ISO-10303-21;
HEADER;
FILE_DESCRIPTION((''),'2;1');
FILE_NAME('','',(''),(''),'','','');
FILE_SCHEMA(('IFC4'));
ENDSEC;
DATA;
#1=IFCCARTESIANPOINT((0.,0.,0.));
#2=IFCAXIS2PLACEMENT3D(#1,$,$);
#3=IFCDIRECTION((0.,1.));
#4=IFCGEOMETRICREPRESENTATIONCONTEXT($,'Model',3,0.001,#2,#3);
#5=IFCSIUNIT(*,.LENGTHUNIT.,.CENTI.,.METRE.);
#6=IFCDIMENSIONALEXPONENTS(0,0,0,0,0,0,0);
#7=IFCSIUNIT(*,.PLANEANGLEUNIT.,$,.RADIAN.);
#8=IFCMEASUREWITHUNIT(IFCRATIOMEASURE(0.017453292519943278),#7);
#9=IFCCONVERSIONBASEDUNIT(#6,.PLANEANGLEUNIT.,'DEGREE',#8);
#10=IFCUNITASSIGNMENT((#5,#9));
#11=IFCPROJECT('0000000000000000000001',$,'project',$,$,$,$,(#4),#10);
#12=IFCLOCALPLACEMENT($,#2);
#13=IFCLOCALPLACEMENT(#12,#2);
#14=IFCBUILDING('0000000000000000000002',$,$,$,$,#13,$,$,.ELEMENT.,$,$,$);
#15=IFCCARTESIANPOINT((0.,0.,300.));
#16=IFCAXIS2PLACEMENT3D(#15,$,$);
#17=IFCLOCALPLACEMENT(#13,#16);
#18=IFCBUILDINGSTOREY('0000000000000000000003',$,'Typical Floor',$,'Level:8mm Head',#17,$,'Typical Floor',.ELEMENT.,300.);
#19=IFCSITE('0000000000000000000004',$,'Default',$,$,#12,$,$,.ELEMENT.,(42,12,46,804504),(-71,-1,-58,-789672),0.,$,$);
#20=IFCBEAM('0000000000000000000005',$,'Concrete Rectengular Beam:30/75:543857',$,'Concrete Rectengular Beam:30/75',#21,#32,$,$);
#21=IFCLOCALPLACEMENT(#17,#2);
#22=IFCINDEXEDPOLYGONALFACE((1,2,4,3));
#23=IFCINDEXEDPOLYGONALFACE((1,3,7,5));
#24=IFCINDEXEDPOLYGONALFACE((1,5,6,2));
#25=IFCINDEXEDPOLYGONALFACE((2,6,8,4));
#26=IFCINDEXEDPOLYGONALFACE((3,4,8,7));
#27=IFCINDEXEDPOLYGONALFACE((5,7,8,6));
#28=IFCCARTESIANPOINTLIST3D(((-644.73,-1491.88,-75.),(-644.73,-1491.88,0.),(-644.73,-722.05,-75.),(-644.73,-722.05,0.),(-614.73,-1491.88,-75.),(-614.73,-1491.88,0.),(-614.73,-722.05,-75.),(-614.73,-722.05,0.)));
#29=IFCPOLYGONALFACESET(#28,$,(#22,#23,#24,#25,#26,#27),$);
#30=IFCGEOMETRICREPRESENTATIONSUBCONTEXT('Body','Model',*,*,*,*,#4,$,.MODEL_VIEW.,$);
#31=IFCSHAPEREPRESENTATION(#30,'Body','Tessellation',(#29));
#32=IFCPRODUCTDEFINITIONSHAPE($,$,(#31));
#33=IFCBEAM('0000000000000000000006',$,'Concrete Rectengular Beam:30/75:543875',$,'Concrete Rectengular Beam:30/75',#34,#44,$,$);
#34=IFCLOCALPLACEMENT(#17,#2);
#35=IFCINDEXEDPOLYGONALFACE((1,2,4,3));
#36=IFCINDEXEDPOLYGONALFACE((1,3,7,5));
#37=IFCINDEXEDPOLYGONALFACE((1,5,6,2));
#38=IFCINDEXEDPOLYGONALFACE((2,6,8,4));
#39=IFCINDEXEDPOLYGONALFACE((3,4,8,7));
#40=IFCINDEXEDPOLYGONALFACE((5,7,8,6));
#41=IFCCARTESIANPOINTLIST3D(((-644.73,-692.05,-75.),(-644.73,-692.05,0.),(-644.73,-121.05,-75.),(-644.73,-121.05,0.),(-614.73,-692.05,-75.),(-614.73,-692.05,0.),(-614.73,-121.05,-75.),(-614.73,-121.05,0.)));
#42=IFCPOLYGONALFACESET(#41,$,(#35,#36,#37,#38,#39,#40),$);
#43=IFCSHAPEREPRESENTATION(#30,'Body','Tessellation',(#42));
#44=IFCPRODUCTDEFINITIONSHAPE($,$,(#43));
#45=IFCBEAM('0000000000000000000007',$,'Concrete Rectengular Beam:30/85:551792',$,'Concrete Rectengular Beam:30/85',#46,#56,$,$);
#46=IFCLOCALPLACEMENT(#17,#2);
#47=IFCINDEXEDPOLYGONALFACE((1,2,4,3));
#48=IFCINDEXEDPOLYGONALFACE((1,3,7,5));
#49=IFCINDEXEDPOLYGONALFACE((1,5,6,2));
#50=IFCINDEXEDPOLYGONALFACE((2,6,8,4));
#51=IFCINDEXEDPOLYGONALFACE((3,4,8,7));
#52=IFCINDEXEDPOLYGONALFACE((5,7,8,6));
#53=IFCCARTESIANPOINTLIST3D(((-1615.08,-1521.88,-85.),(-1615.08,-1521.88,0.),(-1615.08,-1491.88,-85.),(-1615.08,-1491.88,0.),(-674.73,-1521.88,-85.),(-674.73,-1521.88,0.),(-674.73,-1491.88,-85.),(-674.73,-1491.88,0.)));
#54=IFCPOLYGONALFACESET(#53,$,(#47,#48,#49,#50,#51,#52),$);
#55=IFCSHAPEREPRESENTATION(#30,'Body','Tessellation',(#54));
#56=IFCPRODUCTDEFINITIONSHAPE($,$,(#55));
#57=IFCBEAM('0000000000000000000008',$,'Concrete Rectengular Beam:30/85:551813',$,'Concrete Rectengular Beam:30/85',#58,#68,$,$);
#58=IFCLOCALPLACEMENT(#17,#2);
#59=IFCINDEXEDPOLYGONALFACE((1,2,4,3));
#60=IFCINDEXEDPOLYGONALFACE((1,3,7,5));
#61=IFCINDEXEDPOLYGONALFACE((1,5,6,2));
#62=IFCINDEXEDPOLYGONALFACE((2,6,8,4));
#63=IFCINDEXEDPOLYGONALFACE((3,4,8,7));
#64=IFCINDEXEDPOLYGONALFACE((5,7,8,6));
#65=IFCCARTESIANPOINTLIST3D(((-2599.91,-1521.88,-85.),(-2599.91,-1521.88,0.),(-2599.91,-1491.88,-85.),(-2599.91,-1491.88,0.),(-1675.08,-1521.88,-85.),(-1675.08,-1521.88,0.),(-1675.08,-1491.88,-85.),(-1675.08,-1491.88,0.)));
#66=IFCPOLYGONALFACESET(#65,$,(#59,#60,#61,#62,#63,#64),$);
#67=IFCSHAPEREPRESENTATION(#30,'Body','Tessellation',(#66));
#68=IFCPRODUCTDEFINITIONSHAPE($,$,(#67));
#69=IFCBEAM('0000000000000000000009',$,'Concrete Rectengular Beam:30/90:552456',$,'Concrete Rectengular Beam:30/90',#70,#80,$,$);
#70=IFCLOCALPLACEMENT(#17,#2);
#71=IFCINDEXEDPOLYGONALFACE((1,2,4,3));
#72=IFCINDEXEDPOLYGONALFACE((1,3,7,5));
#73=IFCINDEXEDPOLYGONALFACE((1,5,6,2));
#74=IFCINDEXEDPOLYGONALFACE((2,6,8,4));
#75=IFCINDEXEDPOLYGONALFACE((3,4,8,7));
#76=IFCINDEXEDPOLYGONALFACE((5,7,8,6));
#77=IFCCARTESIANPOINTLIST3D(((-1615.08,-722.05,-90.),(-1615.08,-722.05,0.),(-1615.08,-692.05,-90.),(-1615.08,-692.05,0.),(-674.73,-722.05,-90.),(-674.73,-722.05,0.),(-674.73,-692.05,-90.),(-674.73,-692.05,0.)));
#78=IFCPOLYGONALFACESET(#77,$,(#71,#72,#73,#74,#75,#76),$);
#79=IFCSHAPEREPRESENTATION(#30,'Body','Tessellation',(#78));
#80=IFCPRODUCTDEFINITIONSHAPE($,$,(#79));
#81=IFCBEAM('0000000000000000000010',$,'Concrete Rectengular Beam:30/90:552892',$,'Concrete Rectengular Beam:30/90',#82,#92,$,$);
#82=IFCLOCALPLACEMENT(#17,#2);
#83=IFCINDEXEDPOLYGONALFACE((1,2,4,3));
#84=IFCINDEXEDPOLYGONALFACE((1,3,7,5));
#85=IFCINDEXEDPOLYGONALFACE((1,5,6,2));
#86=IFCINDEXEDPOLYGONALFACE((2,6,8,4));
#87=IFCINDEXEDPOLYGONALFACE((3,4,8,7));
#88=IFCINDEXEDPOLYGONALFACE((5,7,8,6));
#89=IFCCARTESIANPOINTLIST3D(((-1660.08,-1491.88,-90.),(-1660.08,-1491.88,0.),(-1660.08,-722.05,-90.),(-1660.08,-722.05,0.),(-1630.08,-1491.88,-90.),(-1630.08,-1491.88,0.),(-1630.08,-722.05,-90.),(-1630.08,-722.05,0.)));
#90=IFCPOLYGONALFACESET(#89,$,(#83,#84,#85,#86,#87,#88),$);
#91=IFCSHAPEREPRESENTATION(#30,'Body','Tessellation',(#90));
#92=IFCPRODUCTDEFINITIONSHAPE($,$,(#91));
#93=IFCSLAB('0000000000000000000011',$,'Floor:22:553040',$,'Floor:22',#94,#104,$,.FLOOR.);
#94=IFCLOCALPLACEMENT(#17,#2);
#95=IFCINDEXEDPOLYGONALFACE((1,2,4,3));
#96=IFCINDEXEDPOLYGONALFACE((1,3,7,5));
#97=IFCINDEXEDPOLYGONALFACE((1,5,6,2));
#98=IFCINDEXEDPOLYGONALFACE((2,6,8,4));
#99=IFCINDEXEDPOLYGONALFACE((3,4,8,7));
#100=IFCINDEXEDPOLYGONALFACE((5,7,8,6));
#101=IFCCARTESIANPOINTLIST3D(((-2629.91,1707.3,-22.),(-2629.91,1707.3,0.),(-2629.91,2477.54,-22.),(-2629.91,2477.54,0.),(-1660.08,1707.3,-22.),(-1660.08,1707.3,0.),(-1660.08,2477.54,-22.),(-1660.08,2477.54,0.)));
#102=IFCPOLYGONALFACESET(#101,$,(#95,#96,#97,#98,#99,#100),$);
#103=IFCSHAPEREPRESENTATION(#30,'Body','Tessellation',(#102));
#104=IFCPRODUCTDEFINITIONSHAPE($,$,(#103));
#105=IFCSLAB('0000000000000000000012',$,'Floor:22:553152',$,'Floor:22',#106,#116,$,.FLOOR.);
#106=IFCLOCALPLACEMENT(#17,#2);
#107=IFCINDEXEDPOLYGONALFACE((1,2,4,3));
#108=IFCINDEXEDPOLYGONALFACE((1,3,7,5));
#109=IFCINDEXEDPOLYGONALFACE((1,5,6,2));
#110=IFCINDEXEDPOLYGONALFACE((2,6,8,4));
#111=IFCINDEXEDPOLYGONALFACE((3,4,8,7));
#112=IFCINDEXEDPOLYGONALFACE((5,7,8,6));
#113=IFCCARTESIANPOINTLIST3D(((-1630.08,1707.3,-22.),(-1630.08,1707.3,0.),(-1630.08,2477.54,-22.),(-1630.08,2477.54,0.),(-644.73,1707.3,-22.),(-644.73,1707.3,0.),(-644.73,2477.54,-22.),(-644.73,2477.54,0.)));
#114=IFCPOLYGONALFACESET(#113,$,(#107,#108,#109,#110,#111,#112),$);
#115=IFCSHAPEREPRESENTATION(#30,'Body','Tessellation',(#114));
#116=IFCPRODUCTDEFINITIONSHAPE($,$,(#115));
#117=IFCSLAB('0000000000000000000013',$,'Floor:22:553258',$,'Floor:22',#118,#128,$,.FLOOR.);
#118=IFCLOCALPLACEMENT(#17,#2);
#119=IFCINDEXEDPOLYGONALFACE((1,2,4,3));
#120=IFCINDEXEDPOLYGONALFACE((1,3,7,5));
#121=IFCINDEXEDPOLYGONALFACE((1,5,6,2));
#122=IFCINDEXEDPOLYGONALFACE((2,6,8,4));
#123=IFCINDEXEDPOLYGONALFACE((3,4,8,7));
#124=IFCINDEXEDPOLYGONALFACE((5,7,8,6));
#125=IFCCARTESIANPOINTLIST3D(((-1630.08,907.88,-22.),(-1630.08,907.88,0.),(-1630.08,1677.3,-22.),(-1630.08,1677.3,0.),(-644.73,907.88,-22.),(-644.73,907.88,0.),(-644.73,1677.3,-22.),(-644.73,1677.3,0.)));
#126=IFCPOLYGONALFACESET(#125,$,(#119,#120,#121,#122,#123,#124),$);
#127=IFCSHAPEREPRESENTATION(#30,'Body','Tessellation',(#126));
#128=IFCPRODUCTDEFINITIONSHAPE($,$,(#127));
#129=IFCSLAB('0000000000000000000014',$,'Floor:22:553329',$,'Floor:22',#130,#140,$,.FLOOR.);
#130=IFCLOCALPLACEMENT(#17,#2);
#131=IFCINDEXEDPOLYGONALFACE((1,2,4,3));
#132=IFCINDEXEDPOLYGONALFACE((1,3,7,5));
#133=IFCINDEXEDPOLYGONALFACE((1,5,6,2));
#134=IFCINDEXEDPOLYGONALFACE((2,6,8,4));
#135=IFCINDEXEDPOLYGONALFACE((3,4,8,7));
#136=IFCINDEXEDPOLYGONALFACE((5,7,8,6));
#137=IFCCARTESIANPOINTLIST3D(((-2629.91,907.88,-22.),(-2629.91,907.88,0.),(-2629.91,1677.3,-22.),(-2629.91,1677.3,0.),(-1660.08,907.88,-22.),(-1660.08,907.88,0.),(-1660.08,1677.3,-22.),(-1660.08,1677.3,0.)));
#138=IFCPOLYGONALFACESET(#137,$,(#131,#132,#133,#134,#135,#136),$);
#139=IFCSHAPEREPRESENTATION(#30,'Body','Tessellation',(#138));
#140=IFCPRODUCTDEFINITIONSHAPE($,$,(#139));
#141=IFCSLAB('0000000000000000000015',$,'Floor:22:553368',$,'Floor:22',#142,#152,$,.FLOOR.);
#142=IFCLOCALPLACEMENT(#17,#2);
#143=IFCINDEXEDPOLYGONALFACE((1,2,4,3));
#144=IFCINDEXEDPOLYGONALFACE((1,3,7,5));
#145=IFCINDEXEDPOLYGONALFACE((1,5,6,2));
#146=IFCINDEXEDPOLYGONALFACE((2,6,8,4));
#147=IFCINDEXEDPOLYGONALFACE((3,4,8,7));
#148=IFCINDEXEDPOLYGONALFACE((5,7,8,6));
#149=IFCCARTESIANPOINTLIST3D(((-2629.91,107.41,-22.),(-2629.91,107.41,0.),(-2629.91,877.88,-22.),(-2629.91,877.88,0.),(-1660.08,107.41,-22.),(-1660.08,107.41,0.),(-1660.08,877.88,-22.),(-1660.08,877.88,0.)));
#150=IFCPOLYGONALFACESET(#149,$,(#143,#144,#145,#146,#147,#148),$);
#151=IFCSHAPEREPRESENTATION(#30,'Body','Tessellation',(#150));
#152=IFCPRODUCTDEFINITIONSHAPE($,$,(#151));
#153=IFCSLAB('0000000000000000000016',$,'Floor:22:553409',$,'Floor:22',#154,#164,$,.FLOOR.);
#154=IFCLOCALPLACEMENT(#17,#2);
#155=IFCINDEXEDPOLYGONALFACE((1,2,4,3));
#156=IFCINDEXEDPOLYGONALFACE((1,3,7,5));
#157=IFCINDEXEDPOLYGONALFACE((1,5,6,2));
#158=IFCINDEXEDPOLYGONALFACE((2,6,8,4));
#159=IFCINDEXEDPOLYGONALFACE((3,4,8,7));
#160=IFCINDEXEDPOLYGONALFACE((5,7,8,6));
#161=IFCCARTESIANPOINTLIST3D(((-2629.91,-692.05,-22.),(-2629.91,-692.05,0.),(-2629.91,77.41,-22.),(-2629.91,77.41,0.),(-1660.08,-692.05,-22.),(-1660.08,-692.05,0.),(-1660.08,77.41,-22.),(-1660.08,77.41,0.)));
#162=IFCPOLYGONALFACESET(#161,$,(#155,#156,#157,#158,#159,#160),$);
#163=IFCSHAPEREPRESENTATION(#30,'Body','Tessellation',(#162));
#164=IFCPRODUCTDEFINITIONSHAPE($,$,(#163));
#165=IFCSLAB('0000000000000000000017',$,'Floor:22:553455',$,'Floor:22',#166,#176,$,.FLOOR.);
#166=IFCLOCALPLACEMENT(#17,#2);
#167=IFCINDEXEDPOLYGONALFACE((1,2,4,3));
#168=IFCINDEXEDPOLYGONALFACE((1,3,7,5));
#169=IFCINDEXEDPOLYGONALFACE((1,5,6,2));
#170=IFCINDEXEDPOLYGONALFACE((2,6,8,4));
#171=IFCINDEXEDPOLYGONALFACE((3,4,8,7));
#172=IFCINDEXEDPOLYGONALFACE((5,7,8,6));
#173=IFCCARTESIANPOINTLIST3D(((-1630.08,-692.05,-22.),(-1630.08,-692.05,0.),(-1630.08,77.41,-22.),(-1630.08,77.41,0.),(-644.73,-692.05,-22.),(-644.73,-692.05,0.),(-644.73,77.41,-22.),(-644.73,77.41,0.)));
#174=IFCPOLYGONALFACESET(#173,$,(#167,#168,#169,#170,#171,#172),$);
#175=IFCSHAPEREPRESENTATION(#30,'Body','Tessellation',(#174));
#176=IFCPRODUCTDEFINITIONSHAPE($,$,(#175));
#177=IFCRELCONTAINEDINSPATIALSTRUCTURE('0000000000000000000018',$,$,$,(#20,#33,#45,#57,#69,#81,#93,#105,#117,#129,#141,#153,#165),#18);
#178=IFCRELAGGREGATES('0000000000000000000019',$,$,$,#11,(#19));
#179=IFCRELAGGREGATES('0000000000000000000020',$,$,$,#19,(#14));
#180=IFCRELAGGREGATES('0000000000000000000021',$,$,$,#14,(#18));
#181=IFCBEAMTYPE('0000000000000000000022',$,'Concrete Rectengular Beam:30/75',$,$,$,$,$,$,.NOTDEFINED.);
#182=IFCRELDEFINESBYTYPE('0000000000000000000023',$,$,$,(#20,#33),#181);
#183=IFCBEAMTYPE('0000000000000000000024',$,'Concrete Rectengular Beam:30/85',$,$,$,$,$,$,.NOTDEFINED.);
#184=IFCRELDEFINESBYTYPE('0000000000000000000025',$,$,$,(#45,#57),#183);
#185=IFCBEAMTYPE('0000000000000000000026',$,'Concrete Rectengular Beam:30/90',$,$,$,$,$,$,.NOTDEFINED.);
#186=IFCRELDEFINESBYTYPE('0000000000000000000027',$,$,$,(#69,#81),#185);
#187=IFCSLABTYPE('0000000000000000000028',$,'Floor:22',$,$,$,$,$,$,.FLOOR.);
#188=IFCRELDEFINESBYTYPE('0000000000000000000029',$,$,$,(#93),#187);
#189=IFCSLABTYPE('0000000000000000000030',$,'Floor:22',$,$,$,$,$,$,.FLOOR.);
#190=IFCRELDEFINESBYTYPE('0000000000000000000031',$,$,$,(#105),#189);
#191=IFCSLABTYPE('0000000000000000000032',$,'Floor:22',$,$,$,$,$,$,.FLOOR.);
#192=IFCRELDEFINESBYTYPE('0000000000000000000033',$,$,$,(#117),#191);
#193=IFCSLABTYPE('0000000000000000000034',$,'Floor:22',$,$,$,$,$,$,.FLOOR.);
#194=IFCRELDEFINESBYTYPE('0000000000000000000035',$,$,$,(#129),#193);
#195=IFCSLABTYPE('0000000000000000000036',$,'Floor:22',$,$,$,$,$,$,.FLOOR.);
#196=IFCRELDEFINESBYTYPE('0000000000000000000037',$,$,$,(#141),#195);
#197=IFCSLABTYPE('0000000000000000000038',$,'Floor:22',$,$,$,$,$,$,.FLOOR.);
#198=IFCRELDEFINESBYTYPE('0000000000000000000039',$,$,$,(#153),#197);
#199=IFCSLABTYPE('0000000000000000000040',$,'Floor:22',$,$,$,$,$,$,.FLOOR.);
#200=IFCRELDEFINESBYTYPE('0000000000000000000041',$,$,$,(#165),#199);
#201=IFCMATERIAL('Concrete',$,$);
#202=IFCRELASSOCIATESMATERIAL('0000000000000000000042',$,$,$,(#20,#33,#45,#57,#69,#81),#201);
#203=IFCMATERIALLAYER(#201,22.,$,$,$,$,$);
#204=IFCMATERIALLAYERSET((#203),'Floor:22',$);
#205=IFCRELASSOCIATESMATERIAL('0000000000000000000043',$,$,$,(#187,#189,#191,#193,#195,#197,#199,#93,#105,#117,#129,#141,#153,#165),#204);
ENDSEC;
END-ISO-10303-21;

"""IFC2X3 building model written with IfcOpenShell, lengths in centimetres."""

from ifc_helpers import new_model, entity, si_unit, converted_unit, direction, frame, frame_2d, origin, origin_2d_with_axis, place, context, subcontext, project, spatial, rectangle, extrude, material, layer, layer_set, layer_usage, type_object, element, save


model = new_model("IFC2X3")

# Units and contexts
model_context = context("Model", 3, precision=0.001, world=origin(), true_north=direction((0.0, 1.0)))
body_context = subcontext(model_context, "Body", "Model", "MODEL_VIEW")
ifc_project = project(units=[si_unit("LENGTHUNIT", "METRE", prefix="CENTI"), converted_unit("PLANEANGLEUNIT", "DEGREE", entity("IfcRatioMeasure", 0.017453292519943278), si_unit("PLANEANGLEUNIT", "RADIAN"), dimensions=[0, 0, 0, 0, 0, 0, 0])], contexts=[model_context])

# Site, building, storey
site_placement = place(None, origin())
site = spatial("IfcSite", under=ifc_project, at=site_placement, Name="Default", CompositionType="ELEMENT", RefLatitude=(42, 12, 46, 804504), RefLongitude=(-71, -1, -58, -789672), RefElevation=0.0)
building_placement = place(site_placement, origin())
building = spatial("IfcBuilding", under=site, at=building_placement, CompositionType="ELEMENT")
storey_placement = place(building_placement, frame((0.0, 0.0, 300.0)))
storey = spatial("IfcBuildingStorey", under=building, at=storey_placement, Name="Typical Floor", ObjectType="Level:8mm Head", LongName="Typical Floor", CompositionType="ELEMENT", Elevation=300.0)

# Beams
ifc_material = material(Name="Concrete")
beam_type_1 = type_object("IfcBeamType", Name="Concrete Rectengular Beam:30/75", PredefinedType="NOTDEFINED")
beam_1_placement = place(storey_placement, frame((-629.73, -1506.88, 0.0), z_axis=(0.0, 0.0, 1.0), x_axis=(0.0, 1.0, 0.0)))
element("IfcBeam", 1, at=beam_1_placement, inside=storey, type_object=beam_type_1, material=ifc_material, Name="Concrete Rectengular Beam:30/75:543857", ObjectType="Concrete Rectengular Beam:30/75", context=body_context, shape_type="SweptSolid", body=[
    extrude(rectangle(XDim=75.0, YDim=30.0, at=frame_2d((0.0, 0.0), x_axis=(1.0, 0.0))), frame((15.0, 0.0, -37.5), z_axis=(1.0, 0.0, 0.0), x_axis=(0.0, 0.0, -1.0)), (0.0, 0.0, 1.0), 769.83),
])
beam_2_placement = place(storey_placement, frame((-629.73, -707.05, 0.0), z_axis=(0.0, 0.0, 1.0), x_axis=(0.0, 1.0, 0.0)))
element("IfcBeam", 2, at=beam_2_placement, inside=storey, type_object=beam_type_1, material=ifc_material, Name="Concrete Rectengular Beam:30/75:543875", ObjectType="Concrete Rectengular Beam:30/75", context=body_context, shape_type="SweptSolid", body=[
    extrude(rectangle(XDim=75.0, YDim=30.0, at=frame_2d((0.0, 0.0), x_axis=(1.0, 0.0))), frame((15.0, 0.0, -37.5), z_axis=(1.0, 0.0, 0.0), x_axis=(0.0, 0.0, -1.0)), (0.0, 0.0, 1.0), 571.0),
])
beam_type_2 = type_object("IfcBeamType", Name="Concrete Rectengular Beam:30/85", PredefinedType="NOTDEFINED")
beam_3_placement = place(storey_placement, frame((-644.73, -1506.88, 0.0), z_axis=(0.0, 0.0, 1.0), x_axis=(-1.0, 0.0, 0.0)))
element("IfcBeam", 3, at=beam_3_placement, inside=storey, type_object=beam_type_2, material=ifc_material, Name="Concrete Rectengular Beam:30/85:551792", ObjectType="Concrete Rectengular Beam:30/85", context=body_context, shape_type="SweptSolid", body=[
    extrude(rectangle(XDim=85.0, YDim=30.0, at=frame_2d((0.0, 0.0), x_axis=(1.0, 0.0))), frame((30.0, 0.0, -42.5), z_axis=(1.0, 0.0, 0.0), x_axis=(0.0, 0.0, -1.0)), (0.0, 0.0, 1.0), 940.35),
])
beam_4_placement = place(storey_placement, frame((-1645.08, -1506.88, 0.0), z_axis=(0.0, 0.0, 1.0), x_axis=(-1.0, 0.0, 0.0)))
element("IfcBeam", 4, at=beam_4_placement, inside=storey, type_object=beam_type_2, material=ifc_material, Name="Concrete Rectengular Beam:30/85:551813", ObjectType="Concrete Rectengular Beam:30/85", context=body_context, shape_type="SweptSolid", body=[
    extrude(rectangle(XDim=85.0, YDim=30.0, at=frame_2d((0.0, 0.0), x_axis=(1.0, 0.0))), frame((30.0, 0.0, -42.5), z_axis=(1.0, 0.0, 0.0), x_axis=(0.0, 0.0, -1.0)), (0.0, 0.0, 1.0), 924.83),
])
beam_type_3 = type_object("IfcBeamType", Name="Concrete Rectengular Beam:30/90", PredefinedType="NOTDEFINED")
beam_5_placement = place(storey_placement, frame((-1645.08, -707.05, 0.0)))
element("IfcBeam", 5, at=beam_5_placement, inside=storey, type_object=beam_type_3, material=ifc_material, Name="Concrete Rectengular Beam:30/90:552456", ObjectType="Concrete Rectengular Beam:30/90", context=body_context, shape_type="SweptSolid", body=[
    extrude(rectangle(XDim=90.0, YDim=30.0, at=frame_2d((0.0, 0.0), x_axis=(1.0, 0.0))), frame((30.0, 0.0, -45.0), z_axis=(1.0, 0.0, 0.0), x_axis=(0.0, 0.0, -1.0)), (0.0, 0.0, 1.0), 940.35),
])
beam_6_placement = place(storey_placement, frame((-1645.08, -707.05, 0.0), z_axis=(0.0, 0.0, 1.0), x_axis=(0.0, -1.0, 0.0)))
element("IfcBeam", 6, at=beam_6_placement, inside=storey, type_object=beam_type_3, material=ifc_material, Name="Concrete Rectengular Beam:30/90:552892", ObjectType="Concrete Rectengular Beam:30/90", context=body_context, shape_type="SweptSolid", body=[
    extrude(rectangle(XDim=90.0, YDim=30.0, at=frame_2d((0.0, 0.0), x_axis=(1.0, 0.0))), frame((15.0, 0.0, -45.0), z_axis=(1.0, 0.0, 0.0), x_axis=(0.0, 0.0, -1.0)), (0.0, 0.0, 1.0), 769.83),
])

# Slabs
ifc_layer = layer(ifc_material, 22.0)
ifc_layer_set = layer_set([ifc_layer], Name="Floor:22")
ifc_layer_usage_1 = layer_usage(ifc_layer_set, "AXIS3", "POSITIVE", 0.0)
slab_type_1 = type_object("IfcSlabType", Name="Floor:22", PredefinedType="FLOOR", material=ifc_layer_set)
slab_1_placement = place(storey_placement, origin())
element("IfcSlab", 7, at=slab_1_placement, inside=storey, type_object=slab_type_1, material=ifc_layer_usage_1, Name="Floor:22:553040", ObjectType="Floor:22", PredefinedType="FLOOR", context=body_context, shape_type="SweptSolid", body=[
    extrude(rectangle(XDim=770.24, YDim=969.83, at=frame_2d((0.0, 0.0), x_axis=(1.0, 0.0))), frame((-2144.99, 2092.42, 0.0), z_axis=(0.0, 0.0, -1.0), x_axis=(0.0, 1.0, 0.0)), (0.0, 0.0, 1.0), 22.0),
])
ifc_layer_usage_2 = layer_usage(ifc_layer_set, "AXIS3", "POSITIVE", 0.0)
slab_type_2 = type_object("IfcSlabType", Name="Floor:22", PredefinedType="FLOOR", material=ifc_layer_set)
slab_2_placement = place(storey_placement, origin())
element("IfcSlab", 8, at=slab_2_placement, inside=storey, type_object=slab_type_2, material=ifc_layer_usage_2, Name="Floor:22:553152", ObjectType="Floor:22", PredefinedType="FLOOR", context=body_context, shape_type="SweptSolid", body=[
    extrude(rectangle(XDim=770.24, YDim=985.35, at=frame_2d((0.0, 0.0), x_axis=(1.0, 0.0))), frame((-1137.41, 2092.42, 0.0), z_axis=(0.0, 0.0, -1.0), x_axis=(0.0, 1.0, 0.0)), (0.0, 0.0, 1.0), 22.0),
])
ifc_layer_usage_3 = layer_usage(ifc_layer_set, "AXIS3", "POSITIVE", 0.0)
slab_type_3 = type_object("IfcSlabType", Name="Floor:22", PredefinedType="FLOOR", material=ifc_layer_set)
slab_3_placement = place(storey_placement, origin())
element("IfcSlab", 9, at=slab_3_placement, inside=storey, type_object=slab_type_3, material=ifc_layer_usage_3, Name="Floor:22:553258", ObjectType="Floor:22", PredefinedType="FLOOR", context=body_context, shape_type="SweptSolid", body=[
    extrude(rectangle(XDim=769.42, YDim=985.35, at=frame_2d((0.0, 0.0), x_axis=(1.0, 0.0))), frame((-1137.41, 1292.59, 0.0), z_axis=(0.0, 0.0, -1.0), x_axis=(0.0, 1.0, 0.0)), (0.0, 0.0, 1.0), 22.0),
])
ifc_layer_usage_4 = layer_usage(ifc_layer_set, "AXIS3", "POSITIVE", 0.0)
slab_type_4 = type_object("IfcSlabType", Name="Floor:22", PredefinedType="FLOOR", material=ifc_layer_set)
slab_4_placement = place(storey_placement, origin())
element("IfcSlab", 10, at=slab_4_placement, inside=storey, type_object=slab_type_4, material=ifc_layer_usage_4, Name="Floor:22:553329", ObjectType="Floor:22", PredefinedType="FLOOR", context=body_context, shape_type="SweptSolid", body=[
    extrude(rectangle(XDim=769.42, YDim=969.83, at=frame_2d((0.0, 0.0), x_axis=(1.0, 0.0))), frame((-2144.99, 1292.59, 0.0), z_axis=(0.0, 0.0, -1.0), x_axis=(0.0, 1.0, 0.0)), (0.0, 0.0, 1.0), 22.0),
])
ifc_layer_usage_5 = layer_usage(ifc_layer_set, "AXIS3", "POSITIVE", 0.0)
slab_type_5 = type_object("IfcSlabType", Name="Floor:22", PredefinedType="FLOOR", material=ifc_layer_set)
slab_5_placement = place(storey_placement, origin())
element("IfcSlab", 11, at=slab_5_placement, inside=storey, type_object=slab_type_5, material=ifc_layer_usage_5, Name="Floor:22:553368", ObjectType="Floor:22", PredefinedType="FLOOR", context=body_context, shape_type="SweptSolid", body=[
    extrude(rectangle(XDim=770.47, YDim=969.83, at=frame_2d((0.0, 0.0), x_axis=(1.0, 0.0))), frame((-2144.99, 492.64, 0.0), z_axis=(0.0, 0.0, -1.0), x_axis=(0.0, 1.0, 0.0)), (0.0, 0.0, 1.0), 22.0),
])
ifc_layer_usage_6 = layer_usage(ifc_layer_set, "AXIS3", "POSITIVE", 0.0)
slab_type_6 = type_object("IfcSlabType", Name="Floor:22", PredefinedType="FLOOR", material=ifc_layer_set)
slab_6_placement = place(storey_placement, origin())
element("IfcSlab", 12, at=slab_6_placement, inside=storey, type_object=slab_type_6, material=ifc_layer_usage_6, Name="Floor:22:553409", ObjectType="Floor:22", PredefinedType="FLOOR", context=body_context, shape_type="SweptSolid", body=[
    extrude(rectangle(XDim=769.46, YDim=969.83, at=origin_2d_with_axis()), frame((-2144.99, -307.32, 0.0), z_axis=(0.0, 0.0, -1.0), x_axis=(0.0, 1.0, 0.0)), (0.0, 0.0, 1.0), 22.0),
])
ifc_layer_usage_7 = layer_usage(ifc_layer_set, "AXIS3", "POSITIVE", 0.0)
slab_type_7 = type_object("IfcSlabType", Name="Floor:22", PredefinedType="FLOOR", material=ifc_layer_set)
slab_7_placement = place(storey_placement, origin())
element("IfcSlab", 13, at=slab_7_placement, inside=storey, type_object=slab_type_7, material=ifc_layer_usage_7, Name="Floor:22:553455", ObjectType="Floor:22", PredefinedType="FLOOR", context=body_context, shape_type="SweptSolid", body=[
    extrude(rectangle(XDim=769.46, YDim=985.35, at=frame_2d((0.0, 0.0), x_axis=(1.0, 0.0))), frame((-1137.41, -307.32, 0.0), z_axis=(0.0, 0.0, -1.0), x_axis=(0.0, 1.0, 0.0)), (0.0, 0.0, 1.0), 22.0),
])

save(model, "model.ifc")
